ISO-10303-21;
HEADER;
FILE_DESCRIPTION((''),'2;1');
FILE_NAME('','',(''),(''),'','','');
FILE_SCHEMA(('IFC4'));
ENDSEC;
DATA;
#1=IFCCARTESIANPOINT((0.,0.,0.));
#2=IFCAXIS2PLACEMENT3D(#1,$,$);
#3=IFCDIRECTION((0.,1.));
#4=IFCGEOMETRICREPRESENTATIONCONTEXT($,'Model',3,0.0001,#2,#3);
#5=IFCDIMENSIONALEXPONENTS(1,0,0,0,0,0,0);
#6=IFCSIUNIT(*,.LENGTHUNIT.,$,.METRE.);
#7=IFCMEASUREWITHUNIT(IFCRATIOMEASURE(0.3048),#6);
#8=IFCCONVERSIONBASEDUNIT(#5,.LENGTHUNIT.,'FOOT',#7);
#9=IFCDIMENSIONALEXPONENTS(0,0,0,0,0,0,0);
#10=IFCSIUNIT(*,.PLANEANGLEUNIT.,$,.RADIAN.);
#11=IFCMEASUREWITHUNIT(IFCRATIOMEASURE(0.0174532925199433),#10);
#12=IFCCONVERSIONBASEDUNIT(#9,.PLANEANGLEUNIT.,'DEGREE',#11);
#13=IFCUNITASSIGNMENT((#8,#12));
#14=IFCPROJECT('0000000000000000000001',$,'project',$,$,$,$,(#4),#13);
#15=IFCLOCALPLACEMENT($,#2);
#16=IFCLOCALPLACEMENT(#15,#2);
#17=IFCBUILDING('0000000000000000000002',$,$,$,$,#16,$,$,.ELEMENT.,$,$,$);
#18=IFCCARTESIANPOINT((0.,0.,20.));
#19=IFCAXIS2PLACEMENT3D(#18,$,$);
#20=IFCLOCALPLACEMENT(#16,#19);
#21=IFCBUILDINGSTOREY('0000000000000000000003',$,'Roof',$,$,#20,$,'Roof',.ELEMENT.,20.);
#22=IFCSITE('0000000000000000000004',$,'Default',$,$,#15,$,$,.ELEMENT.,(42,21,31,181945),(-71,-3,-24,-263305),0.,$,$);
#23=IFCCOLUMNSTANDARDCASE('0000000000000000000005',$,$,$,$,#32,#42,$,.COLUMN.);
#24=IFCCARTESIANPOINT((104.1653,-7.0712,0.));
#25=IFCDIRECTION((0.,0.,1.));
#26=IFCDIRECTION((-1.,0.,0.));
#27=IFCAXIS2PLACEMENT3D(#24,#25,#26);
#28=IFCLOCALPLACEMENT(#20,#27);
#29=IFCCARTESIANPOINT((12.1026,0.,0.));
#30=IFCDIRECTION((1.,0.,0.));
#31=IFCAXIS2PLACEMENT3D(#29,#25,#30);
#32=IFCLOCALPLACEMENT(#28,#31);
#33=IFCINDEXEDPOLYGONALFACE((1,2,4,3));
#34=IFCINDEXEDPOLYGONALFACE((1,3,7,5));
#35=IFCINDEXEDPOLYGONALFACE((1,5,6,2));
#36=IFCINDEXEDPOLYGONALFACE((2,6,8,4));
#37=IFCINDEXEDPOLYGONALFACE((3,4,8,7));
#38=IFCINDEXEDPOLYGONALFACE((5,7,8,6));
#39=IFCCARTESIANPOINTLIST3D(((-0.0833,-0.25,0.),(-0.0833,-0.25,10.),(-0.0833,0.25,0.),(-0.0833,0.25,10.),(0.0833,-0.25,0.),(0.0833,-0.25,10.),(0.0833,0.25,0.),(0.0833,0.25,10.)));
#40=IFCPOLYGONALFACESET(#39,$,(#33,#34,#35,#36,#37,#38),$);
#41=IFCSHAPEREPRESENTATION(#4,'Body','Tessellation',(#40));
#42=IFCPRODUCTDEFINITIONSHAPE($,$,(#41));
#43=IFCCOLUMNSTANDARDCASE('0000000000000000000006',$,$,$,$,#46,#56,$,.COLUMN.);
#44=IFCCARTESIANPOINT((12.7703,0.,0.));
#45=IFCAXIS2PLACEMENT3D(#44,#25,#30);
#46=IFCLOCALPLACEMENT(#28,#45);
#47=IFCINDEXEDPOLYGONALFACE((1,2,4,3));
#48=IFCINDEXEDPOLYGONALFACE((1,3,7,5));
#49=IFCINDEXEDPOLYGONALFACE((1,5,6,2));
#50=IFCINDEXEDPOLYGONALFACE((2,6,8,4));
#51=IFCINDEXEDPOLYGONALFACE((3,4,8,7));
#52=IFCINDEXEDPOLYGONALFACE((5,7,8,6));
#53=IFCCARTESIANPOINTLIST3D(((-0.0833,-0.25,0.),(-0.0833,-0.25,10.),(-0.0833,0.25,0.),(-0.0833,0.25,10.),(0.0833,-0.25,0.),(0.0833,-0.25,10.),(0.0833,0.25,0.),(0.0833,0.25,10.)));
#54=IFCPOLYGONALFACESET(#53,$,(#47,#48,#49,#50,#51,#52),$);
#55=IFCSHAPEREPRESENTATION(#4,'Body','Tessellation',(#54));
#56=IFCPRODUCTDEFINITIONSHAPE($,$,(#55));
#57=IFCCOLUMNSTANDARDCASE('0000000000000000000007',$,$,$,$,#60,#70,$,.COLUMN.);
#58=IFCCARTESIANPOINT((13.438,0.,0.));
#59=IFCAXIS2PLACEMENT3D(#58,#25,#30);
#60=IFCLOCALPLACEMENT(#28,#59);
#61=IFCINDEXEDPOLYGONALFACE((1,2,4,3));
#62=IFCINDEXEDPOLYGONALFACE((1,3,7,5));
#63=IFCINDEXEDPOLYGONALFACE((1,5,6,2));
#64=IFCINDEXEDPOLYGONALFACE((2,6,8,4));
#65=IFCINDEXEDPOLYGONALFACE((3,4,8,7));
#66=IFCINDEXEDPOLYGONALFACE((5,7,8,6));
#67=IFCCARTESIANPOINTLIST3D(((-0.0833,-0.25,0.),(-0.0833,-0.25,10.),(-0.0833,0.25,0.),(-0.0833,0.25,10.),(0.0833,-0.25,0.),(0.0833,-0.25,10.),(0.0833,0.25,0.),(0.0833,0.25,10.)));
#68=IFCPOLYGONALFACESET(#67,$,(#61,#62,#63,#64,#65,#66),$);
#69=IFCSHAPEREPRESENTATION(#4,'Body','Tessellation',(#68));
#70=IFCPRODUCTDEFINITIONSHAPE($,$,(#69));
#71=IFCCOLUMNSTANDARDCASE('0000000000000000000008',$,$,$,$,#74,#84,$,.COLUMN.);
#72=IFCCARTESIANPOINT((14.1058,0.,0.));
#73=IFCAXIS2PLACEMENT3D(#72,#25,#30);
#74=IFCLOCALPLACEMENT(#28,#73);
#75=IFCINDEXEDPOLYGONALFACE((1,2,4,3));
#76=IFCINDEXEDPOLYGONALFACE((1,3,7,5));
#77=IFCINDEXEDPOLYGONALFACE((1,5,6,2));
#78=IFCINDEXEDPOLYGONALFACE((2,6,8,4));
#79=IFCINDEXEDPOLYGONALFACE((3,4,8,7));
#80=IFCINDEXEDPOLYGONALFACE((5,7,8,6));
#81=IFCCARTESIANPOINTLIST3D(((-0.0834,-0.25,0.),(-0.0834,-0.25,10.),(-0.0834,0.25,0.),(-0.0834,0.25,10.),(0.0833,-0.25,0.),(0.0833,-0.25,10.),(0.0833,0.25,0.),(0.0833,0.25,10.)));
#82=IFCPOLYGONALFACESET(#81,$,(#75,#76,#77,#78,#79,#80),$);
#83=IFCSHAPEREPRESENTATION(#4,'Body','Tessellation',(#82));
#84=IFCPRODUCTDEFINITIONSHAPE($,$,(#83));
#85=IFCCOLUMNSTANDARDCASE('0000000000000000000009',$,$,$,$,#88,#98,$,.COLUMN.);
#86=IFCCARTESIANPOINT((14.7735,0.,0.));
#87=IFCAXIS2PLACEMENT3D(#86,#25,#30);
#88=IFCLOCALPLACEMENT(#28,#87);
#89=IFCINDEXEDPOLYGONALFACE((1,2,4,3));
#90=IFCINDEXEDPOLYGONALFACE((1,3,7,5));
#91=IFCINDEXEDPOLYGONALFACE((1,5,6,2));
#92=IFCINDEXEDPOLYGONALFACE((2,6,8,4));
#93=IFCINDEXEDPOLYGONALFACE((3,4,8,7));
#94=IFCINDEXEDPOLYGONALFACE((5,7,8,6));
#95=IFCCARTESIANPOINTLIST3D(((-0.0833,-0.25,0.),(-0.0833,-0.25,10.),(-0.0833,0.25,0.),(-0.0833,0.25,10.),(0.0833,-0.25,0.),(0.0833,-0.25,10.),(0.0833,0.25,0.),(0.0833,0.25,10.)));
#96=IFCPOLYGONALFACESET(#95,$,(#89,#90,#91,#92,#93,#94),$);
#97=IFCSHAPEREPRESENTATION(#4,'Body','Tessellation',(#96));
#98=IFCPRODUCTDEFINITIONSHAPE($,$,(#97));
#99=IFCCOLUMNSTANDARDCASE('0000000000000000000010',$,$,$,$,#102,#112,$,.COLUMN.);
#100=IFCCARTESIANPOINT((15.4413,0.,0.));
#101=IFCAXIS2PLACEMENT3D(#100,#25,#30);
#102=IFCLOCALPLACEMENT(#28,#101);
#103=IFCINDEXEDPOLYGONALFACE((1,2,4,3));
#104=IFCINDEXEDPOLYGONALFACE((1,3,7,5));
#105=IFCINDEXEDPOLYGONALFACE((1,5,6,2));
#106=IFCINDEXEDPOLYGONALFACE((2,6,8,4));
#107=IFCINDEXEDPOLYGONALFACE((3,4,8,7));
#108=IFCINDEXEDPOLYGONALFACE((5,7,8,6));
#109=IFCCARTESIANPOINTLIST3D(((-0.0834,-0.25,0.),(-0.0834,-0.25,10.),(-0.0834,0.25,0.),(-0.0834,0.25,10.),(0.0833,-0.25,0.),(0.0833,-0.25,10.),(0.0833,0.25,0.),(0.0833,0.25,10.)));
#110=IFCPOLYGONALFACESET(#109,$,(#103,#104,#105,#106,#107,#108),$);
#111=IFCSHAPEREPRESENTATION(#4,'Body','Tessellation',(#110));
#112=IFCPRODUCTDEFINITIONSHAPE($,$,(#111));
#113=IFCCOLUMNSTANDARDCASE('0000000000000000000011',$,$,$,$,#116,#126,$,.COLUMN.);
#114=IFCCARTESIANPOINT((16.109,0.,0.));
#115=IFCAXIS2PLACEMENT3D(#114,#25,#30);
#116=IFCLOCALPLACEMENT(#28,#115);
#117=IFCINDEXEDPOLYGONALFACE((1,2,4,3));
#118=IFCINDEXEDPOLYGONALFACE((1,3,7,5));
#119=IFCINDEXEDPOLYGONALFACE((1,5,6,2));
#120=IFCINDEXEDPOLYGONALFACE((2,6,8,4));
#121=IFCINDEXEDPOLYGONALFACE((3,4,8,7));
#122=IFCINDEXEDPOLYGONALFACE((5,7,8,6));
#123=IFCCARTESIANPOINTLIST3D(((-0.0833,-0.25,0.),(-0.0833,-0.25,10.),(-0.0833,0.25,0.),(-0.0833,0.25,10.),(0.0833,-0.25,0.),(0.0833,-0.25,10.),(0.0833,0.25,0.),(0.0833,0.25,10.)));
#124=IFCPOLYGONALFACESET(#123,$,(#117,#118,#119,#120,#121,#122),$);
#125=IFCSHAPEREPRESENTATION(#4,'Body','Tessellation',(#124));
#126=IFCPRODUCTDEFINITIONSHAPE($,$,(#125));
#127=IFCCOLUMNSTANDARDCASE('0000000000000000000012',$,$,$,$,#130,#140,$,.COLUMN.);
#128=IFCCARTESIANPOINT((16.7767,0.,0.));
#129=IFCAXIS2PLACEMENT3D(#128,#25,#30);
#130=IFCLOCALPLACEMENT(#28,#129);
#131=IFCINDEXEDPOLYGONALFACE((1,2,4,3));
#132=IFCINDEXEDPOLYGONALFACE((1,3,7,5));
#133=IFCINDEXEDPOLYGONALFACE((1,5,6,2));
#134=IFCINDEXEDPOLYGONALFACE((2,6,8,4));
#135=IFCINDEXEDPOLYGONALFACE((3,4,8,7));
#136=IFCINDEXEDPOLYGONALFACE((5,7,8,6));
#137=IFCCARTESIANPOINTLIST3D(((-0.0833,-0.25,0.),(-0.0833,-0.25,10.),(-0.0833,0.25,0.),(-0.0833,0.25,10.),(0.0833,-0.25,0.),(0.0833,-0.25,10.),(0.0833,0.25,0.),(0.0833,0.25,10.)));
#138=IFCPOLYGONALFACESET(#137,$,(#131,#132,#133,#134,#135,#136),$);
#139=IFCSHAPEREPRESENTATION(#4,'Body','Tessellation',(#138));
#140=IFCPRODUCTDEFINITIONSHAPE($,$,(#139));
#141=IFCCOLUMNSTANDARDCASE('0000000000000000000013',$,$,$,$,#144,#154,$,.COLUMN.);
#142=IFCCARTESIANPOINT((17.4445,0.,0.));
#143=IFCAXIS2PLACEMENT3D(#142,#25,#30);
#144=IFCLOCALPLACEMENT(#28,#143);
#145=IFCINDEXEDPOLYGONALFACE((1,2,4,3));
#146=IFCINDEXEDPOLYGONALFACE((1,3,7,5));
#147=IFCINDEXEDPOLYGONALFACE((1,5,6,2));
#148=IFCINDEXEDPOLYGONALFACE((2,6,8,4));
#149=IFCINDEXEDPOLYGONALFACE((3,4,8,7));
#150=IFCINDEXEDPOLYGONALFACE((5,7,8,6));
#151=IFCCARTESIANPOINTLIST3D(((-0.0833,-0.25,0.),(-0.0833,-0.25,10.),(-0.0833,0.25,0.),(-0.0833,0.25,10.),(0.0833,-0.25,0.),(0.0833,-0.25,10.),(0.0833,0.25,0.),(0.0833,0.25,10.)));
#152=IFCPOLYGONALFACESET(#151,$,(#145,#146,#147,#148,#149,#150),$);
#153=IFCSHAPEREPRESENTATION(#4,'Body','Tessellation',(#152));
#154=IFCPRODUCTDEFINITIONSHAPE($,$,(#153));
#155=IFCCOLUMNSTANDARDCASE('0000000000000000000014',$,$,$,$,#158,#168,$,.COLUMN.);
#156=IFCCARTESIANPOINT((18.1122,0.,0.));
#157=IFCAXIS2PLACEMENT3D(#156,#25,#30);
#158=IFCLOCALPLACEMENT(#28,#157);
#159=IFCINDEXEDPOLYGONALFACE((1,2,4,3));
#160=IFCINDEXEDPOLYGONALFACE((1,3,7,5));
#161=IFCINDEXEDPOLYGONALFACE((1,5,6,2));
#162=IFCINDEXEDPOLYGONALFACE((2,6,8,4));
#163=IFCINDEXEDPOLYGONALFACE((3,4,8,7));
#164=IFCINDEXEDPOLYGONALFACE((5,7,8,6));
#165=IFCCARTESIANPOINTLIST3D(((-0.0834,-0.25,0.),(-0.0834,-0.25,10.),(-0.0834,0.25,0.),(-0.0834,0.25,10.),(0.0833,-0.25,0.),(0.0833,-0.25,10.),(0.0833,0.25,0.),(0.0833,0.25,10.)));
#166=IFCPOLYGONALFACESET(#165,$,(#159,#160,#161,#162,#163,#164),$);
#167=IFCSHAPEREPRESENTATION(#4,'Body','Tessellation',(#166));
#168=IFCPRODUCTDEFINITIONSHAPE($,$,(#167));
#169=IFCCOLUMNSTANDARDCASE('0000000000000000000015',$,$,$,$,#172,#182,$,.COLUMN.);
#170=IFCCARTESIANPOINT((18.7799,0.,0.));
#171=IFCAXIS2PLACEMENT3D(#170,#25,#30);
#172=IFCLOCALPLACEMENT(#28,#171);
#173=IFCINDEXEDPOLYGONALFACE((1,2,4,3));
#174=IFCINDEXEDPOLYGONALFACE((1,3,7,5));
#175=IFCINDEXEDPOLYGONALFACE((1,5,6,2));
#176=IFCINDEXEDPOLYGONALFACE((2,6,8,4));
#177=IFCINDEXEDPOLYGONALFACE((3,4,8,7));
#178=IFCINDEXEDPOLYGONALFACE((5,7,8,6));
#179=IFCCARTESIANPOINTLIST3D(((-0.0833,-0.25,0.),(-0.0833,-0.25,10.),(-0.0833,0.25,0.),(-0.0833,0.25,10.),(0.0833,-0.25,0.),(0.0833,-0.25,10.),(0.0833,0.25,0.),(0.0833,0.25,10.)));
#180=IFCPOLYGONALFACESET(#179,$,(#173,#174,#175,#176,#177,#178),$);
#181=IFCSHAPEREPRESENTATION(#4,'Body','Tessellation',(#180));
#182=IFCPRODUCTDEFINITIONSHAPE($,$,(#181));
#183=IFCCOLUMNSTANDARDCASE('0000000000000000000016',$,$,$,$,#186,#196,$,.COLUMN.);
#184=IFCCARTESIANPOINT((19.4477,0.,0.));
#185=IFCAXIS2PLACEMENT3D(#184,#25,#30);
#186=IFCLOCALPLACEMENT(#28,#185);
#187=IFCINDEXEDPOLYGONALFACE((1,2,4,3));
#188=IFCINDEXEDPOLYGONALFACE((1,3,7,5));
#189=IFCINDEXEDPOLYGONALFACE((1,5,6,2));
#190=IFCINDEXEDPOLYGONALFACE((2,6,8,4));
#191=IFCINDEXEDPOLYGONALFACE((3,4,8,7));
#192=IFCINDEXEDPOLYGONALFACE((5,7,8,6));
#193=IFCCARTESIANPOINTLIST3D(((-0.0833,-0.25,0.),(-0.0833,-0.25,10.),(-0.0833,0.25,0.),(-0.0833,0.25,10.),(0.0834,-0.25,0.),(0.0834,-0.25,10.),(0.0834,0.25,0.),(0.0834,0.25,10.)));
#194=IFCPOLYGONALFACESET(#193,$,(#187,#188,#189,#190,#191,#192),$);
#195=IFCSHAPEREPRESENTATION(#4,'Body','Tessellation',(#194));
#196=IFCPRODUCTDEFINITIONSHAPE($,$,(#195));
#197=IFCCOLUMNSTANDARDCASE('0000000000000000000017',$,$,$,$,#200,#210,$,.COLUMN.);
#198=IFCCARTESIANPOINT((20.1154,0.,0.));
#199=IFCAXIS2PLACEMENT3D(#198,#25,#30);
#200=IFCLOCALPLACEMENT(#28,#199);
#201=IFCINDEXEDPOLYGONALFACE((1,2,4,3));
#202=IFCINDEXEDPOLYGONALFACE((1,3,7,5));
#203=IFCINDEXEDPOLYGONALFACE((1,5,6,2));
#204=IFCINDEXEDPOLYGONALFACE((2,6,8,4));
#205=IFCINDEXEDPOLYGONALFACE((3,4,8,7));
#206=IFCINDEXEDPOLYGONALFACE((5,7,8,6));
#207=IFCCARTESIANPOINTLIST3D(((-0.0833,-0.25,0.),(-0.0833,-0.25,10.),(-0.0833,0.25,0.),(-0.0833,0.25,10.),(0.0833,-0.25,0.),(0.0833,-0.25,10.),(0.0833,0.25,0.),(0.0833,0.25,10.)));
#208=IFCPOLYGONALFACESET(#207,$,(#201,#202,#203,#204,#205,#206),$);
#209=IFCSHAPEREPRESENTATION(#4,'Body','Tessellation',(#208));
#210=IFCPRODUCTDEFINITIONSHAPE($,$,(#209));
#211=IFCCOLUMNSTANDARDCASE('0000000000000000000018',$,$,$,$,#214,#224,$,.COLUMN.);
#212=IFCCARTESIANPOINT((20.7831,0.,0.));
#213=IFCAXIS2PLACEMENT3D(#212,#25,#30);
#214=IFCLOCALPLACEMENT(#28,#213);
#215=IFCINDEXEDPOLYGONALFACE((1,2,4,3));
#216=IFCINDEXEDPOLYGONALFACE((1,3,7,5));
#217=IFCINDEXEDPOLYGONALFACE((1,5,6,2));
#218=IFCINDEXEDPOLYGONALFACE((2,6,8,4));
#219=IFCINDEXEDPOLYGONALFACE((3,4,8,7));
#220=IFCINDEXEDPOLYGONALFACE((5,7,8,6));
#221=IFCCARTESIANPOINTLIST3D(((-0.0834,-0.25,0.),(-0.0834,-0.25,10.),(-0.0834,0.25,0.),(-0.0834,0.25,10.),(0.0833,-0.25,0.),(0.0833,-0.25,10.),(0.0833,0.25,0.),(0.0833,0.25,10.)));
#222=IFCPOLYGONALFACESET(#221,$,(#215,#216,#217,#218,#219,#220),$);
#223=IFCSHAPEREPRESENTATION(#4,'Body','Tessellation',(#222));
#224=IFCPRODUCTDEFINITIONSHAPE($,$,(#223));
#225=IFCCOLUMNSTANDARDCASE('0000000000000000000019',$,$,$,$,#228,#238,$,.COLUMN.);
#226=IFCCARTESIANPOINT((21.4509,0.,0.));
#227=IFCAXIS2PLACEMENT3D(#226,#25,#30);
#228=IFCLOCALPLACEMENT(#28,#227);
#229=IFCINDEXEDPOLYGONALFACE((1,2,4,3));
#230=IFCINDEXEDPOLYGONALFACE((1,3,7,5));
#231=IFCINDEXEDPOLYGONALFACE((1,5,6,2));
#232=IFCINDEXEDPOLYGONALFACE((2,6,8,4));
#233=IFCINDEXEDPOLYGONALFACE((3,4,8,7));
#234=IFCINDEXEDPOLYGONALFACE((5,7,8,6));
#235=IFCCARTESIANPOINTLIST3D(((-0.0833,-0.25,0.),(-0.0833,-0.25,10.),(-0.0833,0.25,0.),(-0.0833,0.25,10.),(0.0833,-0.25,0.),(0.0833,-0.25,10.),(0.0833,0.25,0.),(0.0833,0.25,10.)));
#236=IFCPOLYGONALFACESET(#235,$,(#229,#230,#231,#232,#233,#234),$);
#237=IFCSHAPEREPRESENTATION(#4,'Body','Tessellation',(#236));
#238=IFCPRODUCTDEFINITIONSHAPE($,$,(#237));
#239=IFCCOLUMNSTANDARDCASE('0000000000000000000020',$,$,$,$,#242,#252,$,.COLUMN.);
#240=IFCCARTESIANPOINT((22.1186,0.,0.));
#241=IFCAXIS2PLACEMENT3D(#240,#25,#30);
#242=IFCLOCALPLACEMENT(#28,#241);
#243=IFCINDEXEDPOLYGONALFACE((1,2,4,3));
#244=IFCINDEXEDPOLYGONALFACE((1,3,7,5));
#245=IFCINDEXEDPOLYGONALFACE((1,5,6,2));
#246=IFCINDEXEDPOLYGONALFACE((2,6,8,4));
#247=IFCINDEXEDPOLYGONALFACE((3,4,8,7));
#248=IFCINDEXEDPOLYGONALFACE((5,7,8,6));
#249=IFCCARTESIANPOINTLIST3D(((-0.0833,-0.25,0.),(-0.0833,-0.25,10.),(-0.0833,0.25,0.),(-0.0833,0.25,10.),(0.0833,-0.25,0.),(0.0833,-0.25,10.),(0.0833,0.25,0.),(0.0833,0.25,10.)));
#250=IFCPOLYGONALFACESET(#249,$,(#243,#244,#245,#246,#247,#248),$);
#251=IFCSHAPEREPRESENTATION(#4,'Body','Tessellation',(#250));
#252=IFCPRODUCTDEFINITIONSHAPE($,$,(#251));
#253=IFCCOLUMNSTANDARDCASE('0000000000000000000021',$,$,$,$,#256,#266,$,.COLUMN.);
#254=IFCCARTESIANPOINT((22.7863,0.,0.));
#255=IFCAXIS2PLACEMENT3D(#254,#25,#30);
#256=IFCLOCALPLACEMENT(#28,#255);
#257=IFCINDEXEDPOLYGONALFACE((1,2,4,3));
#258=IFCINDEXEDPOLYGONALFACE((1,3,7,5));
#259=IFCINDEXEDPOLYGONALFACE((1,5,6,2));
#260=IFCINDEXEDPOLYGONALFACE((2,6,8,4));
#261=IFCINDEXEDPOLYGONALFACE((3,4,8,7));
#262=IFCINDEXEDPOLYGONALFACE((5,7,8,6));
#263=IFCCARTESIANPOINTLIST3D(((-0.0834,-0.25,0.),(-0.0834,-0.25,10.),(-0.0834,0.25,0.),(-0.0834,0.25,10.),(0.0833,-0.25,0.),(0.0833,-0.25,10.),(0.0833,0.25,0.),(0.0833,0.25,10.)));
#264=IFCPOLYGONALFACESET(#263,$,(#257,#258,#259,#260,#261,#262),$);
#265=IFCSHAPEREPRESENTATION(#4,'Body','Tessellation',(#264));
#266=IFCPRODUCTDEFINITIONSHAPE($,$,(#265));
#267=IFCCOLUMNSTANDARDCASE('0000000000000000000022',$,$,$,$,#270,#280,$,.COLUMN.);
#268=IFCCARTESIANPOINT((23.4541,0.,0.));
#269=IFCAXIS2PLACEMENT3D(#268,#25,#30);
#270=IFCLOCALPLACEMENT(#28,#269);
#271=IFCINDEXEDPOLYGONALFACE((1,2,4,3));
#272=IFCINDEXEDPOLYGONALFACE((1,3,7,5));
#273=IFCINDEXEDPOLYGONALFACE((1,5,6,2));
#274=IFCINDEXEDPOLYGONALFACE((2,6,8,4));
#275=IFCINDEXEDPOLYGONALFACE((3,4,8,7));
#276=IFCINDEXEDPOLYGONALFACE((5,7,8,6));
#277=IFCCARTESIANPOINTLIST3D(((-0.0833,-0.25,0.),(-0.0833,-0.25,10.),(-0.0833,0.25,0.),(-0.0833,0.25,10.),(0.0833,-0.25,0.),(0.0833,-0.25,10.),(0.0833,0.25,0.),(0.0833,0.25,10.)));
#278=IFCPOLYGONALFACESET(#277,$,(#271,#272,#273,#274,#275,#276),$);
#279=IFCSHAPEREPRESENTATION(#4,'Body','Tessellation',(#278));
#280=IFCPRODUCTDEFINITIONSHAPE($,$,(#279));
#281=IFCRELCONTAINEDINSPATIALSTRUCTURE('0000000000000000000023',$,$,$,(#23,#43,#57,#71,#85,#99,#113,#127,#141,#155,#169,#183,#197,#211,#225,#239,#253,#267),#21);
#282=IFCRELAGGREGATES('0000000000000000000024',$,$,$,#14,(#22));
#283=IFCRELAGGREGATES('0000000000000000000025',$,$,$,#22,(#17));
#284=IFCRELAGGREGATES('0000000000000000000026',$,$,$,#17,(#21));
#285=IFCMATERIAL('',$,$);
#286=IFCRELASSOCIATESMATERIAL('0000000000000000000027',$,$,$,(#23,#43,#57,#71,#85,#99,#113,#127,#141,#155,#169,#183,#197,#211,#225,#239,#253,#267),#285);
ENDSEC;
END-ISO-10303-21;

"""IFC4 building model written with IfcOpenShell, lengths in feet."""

from ifc_helpers import new_model, entity, si_unit, converted_unit, direction, frame, origin, place, context, project, spatial, rectangle, extrude, material, element, save


model = new_model("IFC4")

# Units and contexts
model_context = context("Model", 3, precision=0.0001, world=origin(), true_north=direction((0.0, 1.0)))
ifc_project = project(units=[converted_unit("LENGTHUNIT", "FOOT", entity("IfcRatioMeasure", 0.3048), si_unit("LENGTHUNIT", "METRE"), dimensions=[1, 0, 0, 0, 0, 0, 0]), converted_unit("PLANEANGLEUNIT", "DEGREE", entity("IfcRatioMeasure", 0.0174532925199433), si_unit("PLANEANGLEUNIT", "RADIAN"), dimensions=[0, 0, 0, 0, 0, 0, 0])], contexts=[model_context])

# Site, building, storey
site_placement = place(None, origin())
site = spatial("IfcSite", under=ifc_project, at=site_placement, Name="Default", CompositionType="ELEMENT", RefLatitude=(42, 21, 31, 181945), RefLongitude=(-71, -3, -24, -263305), RefElevation=0.0)
building_placement = place(site_placement, origin())
building = spatial("IfcBuilding", under=site, at=building_placement, CompositionType="ELEMENT")
storey_placement = place(building_placement, frame((0.0, 0.0, 20.0)))
storey = spatial("IfcBuildingStorey", under=building, at=storey_placement, Name="Roof", LongName="Roof", CompositionType="ELEMENT", Elevation=20.0)

# Columns
ifc_material = material(Name="")
placement = place(storey_placement, frame((104.1653, -7.0712, 0.0), z_axis=(0.0, 0.0, 1.0), x_axis=(-1.0, 0.0, 0.0)))
for number, where, z_axis, x_axis in (
    (1, (12.1026, 0.0, 0.0), (0.0, 0.0, 1.0), (1.0, 0.0, 0.0)),
    (2, (12.7703, 0.0, 0.0), (0.0, 0.0, 1.0), (1.0, 0.0, 0.0)),
    (3, (13.438, 0.0, 0.0), (0.0, 0.0, 1.0), (1.0, 0.0, 0.0)),
    (4, (14.1058, 0.0, 0.0), (0.0, 0.0, 1.0), (1.0, 0.0, 0.0)),
    (5, (14.7735, 0.0, 0.0), (0.0, 0.0, 1.0), (1.0, 0.0, 0.0)),
    (6, (15.4413, 0.0, 0.0), (0.0, 0.0, 1.0), (1.0, 0.0, 0.0)),
    (7, (16.109, 0.0, 0.0), (0.0, 0.0, 1.0), (1.0, 0.0, 0.0)),
    (8, (16.7767, 0.0, 0.0), (0.0, 0.0, 1.0), (1.0, 0.0, 0.0)),
    (9, (17.4445, 0.0, 0.0), (0.0, 0.0, 1.0), (1.0, 0.0, 0.0)),
    (10, (18.1122, 0.0, 0.0), (0.0, 0.0, 1.0), (1.0, 0.0, 0.0)),
    (11, (18.7799, 0.0, 0.0), (0.0, 0.0, 1.0), (1.0, 0.0, 0.0)),
    (12, (19.4477, 0.0, 0.0), (0.0, 0.0, 1.0), (1.0, 0.0, 0.0)),
    (13, (20.1154, 0.0, 0.0), (0.0, 0.0, 1.0), (1.0, 0.0, 0.0)),
    (14, (20.7831, 0.0, 0.0), (0.0, 0.0, 1.0), (1.0, 0.0, 0.0)),
    (15, (21.4509, 0.0, 0.0), (0.0, 0.0, 1.0), (1.0, 0.0, 0.0)),
    (16, (22.1186, 0.0, 0.0), (0.0, 0.0, 1.0), (1.0, 0.0, 0.0)),
    (17, (22.7863, 0.0, 0.0), (0.0, 0.0, 1.0), (1.0, 0.0, 0.0)),
    (18, (23.4541, 0.0, 0.0), (0.0, 0.0, 1.0), (1.0, 0.0, 0.0)),
):
    element("IfcColumnStandardCase", number, at=place(placement, frame(where, z_axis=z_axis, x_axis=x_axis)), inside=storey, material=ifc_material, PredefinedType="COLUMN", context=model_context, shape_type="SweptSolid", body=[
        extrude(rectangle(XDim=0.1667, YDim=0.5), origin(), (0.0, 0.0, 1.0), 10.0),
    ])

save(model, "model.ifc")
